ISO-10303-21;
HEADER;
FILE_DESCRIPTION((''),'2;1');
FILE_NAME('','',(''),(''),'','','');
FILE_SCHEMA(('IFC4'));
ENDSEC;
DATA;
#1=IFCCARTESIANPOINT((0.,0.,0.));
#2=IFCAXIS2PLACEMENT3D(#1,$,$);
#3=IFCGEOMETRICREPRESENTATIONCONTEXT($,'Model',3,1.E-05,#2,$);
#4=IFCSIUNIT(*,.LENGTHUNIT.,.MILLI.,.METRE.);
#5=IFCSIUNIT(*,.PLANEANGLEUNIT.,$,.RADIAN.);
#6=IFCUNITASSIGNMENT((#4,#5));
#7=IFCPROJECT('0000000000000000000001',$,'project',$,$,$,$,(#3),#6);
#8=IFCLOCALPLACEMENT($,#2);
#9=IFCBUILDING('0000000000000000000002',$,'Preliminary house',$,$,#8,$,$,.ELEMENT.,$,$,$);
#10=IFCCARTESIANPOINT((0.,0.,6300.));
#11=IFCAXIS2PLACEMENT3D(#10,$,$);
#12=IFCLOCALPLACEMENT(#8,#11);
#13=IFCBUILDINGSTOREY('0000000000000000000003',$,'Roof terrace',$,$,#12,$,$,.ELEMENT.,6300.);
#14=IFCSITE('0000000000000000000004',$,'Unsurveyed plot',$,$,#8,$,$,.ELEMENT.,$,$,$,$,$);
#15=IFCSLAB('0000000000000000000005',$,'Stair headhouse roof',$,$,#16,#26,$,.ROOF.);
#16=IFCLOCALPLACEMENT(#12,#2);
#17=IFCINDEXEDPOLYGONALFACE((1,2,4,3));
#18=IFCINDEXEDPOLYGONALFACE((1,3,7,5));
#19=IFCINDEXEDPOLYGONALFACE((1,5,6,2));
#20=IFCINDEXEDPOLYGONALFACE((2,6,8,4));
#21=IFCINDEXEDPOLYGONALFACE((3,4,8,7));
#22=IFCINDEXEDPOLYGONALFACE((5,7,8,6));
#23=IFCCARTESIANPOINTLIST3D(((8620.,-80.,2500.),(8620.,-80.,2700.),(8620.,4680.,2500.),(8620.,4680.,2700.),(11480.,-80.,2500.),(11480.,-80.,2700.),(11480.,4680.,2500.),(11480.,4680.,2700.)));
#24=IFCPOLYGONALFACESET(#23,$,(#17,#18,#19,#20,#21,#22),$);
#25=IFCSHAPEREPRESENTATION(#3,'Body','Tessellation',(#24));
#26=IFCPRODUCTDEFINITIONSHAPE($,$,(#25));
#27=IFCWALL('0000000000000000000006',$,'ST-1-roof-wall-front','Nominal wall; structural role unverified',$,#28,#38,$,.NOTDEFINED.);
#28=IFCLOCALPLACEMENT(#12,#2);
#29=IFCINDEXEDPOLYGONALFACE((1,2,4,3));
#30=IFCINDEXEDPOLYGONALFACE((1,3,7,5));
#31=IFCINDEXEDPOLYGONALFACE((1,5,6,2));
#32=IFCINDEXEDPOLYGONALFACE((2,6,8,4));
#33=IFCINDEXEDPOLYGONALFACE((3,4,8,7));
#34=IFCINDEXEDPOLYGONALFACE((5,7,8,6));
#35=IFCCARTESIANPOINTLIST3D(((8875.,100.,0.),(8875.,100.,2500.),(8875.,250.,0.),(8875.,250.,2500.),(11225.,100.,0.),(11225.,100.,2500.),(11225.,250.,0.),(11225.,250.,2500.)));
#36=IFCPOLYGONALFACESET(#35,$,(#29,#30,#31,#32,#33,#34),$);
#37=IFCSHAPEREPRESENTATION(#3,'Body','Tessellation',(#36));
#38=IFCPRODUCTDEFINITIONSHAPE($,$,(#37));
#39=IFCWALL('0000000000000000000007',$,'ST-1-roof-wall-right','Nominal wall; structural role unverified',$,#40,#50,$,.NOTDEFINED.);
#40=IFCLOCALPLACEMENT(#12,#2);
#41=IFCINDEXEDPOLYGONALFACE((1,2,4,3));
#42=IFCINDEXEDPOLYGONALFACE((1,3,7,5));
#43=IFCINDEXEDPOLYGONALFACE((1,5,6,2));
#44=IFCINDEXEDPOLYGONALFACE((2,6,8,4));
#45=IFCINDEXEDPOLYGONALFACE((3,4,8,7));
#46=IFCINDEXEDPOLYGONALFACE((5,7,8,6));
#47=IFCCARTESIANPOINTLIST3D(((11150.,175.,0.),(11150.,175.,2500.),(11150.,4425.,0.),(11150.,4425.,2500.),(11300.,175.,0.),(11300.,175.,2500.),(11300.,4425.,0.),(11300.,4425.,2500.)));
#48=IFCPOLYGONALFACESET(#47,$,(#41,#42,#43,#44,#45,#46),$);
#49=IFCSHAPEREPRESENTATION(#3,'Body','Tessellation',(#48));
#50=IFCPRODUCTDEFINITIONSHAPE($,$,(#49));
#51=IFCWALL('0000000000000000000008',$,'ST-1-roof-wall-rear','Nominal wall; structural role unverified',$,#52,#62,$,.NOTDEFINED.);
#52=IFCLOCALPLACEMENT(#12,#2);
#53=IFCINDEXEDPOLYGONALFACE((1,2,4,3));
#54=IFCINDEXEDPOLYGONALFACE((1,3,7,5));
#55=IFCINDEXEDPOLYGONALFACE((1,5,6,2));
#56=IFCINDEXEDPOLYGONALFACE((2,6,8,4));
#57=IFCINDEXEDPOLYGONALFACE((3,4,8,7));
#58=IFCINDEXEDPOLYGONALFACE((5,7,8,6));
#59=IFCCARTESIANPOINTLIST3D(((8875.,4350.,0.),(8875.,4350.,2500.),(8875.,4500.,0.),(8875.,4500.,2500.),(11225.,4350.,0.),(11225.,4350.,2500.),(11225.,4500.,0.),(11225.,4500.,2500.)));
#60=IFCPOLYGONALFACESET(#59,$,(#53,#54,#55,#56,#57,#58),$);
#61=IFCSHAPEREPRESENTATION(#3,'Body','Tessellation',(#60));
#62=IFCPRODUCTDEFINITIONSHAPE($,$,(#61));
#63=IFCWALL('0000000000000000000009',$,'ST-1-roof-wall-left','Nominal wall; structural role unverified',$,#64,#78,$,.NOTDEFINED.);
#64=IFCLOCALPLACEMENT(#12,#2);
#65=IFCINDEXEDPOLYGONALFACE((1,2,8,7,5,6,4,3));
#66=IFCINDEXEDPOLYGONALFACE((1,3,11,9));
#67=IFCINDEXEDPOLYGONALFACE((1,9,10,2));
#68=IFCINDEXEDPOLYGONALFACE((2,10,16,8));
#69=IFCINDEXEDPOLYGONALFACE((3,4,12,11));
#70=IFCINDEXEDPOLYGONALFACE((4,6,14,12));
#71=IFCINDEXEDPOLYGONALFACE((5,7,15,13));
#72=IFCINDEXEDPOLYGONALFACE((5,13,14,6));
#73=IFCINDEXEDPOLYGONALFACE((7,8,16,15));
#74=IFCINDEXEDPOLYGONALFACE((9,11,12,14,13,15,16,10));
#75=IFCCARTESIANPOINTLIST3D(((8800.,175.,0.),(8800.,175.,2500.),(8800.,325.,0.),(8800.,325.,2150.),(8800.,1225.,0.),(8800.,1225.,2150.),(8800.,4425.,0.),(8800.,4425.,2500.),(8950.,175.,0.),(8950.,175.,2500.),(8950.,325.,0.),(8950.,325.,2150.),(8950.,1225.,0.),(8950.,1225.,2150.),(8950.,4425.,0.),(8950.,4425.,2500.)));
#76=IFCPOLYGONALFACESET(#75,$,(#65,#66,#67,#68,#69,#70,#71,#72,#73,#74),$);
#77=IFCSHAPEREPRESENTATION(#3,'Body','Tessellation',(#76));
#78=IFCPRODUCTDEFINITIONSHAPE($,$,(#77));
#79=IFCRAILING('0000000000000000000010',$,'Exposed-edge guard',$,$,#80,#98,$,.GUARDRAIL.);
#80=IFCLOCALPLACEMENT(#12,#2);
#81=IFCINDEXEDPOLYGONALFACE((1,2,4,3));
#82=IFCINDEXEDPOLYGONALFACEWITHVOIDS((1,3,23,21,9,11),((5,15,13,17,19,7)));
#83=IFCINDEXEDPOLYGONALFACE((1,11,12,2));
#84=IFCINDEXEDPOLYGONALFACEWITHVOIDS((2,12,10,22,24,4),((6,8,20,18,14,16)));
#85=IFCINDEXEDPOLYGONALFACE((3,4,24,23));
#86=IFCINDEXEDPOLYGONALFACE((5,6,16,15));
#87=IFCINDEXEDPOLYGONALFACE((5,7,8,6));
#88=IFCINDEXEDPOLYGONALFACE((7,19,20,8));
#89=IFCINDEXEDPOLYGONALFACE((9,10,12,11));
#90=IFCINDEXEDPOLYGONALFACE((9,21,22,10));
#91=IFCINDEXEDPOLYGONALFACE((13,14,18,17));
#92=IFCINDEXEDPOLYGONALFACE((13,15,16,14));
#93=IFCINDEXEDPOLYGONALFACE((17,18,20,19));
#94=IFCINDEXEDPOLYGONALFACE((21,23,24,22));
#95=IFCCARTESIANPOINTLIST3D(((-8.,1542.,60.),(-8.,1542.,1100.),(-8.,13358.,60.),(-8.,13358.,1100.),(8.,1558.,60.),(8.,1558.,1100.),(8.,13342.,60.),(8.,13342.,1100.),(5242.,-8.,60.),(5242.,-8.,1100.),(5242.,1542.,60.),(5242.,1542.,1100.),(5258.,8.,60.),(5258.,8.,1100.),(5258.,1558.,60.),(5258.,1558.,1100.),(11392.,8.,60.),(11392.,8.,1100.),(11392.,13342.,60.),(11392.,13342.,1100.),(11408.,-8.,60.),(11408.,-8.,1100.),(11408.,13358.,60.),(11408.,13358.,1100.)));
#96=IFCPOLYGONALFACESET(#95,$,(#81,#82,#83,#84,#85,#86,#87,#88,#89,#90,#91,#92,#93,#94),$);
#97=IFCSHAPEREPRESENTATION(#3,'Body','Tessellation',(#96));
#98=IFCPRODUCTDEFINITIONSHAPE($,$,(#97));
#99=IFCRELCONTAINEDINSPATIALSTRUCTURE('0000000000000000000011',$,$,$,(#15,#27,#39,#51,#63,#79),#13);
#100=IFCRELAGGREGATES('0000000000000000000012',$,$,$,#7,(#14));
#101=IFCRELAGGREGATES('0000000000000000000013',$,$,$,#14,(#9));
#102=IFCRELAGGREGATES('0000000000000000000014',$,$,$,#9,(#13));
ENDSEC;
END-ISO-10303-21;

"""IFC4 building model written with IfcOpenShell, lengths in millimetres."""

from ifc_helpers import new_model, si_unit, frame, origin, place, context, project, spatial, polyline, outline, extrude, element, save


model = new_model("IFC4")

# Units and contexts
model_context = context("Model", 3, precision=1e-05, world=origin())
ifc_project = project(units=[si_unit("LENGTHUNIT", "METRE", prefix="MILLI"), si_unit("PLANEANGLEUNIT", "RADIAN")], contexts=[model_context])

# Site, building, storey
placement_1 = place(None, origin())
site = spatial("IfcSite", under=ifc_project, at=placement_1, Name="Unsurveyed plot", CompositionType="ELEMENT")
building = spatial("IfcBuilding", under=site, at=placement_1, Name="Preliminary house", CompositionType="ELEMENT")
placement_2 = place(placement_1, frame((0.0, 0.0, 6300.0)))
storey = spatial("IfcBuildingStorey", under=building, at=placement_2, Name="Roof terrace", CompositionType="ELEMENT", Elevation=6300.0)

# Slab
element("IfcSlab", 1, at=placement_2, inside=storey, Name="Stair headhouse roof", PredefinedType="ROOF", context=model_context, shape_type="SweptSolid", body=[
    extrude(outline(polyline([(11480.0, -80.0), (8620.0, -80.0), (8620.0, 4680.0), (11480.0, 4680.0), (11480.0, -80.0)])), frame((0.0, 0.0, 2500.0)), (0.0, 0.0, 1.0), 200.0),
])

# Walls
element("IfcWall", 2, at=placement_2, inside=storey, Name="ST-1-roof-wall-front", Description="Nominal wall; structural role unverified", PredefinedType="NOTDEFINED", context=model_context, shape_type="SweptSolid", body=[
    extrude(outline(polyline([(11225.0, 250.0), (11225.0, 100.0), (8875.0, 100.0), (8875.0, 250.0), (11225.0, 250.0)])), origin(), (0.0, 0.0, 1.0), 2500.0),
])
element("IfcWall", 3, at=placement_2, inside=storey, Name="ST-1-roof-wall-right", Description="Nominal wall; structural role unverified", PredefinedType="NOTDEFINED", context=model_context, shape_type="SweptSolid", body=[
    extrude(outline(polyline([(11150.0, 4425.0), (11300.0, 4425.0), (11300.0, 175.0), (11150.0, 175.0), (11150.0, 4425.0)])), origin(), (0.0, 0.0, 1.0), 2500.0),
])
element("IfcWall", 4, at=placement_2, inside=storey, Name="ST-1-roof-wall-rear", Description="Nominal wall; structural role unverified", PredefinedType="NOTDEFINED", context=model_context, shape_type="SweptSolid", body=[
    extrude(outline(polyline([(11225.0, 4500.0), (11225.0, 4350.0), (8875.0, 4350.0), (8875.0, 4500.0), (11225.0, 4500.0)])), origin(), (0.0, 0.0, 1.0), 2500.0),
])

# Wall, opening
wall_1 = element("IfcWall", 5, at=placement_2, inside=storey, Name="ST-1-roof-wall-left", Description="Nominal wall; structural role unverified", PredefinedType="NOTDEFINED", context=model_context, shape_type="SweptSolid", body=[
    extrude(outline(polyline([(8800.0, 4425.0), (8950.0, 4425.0), (8950.0, 175.0), (8800.0, 175.0), (8800.0, 4425.0)])), origin(), (0.0, 0.0, 1.0), 2500.0),
])
element("IfcOpeningElement", 6, at=placement_2, cuts=wall_1, PredefinedType="OPENING", context=model_context, shape_type="SweptSolid", body=[
    extrude(outline(polyline([(9325.0, 325.0), (9325.0, 1225.0), (8425.0, 1225.0), (8425.0, 325.0), (9325.0, 325.0)])), origin(), (0.0, 0.0, 1.0), 2150.0),
])

# Railing
element("IfcRailing", 7, at=placement_2, inside=storey, Name="Exposed-edge guard", PredefinedType="GUARDRAIL", context=model_context, shape_type="SweptSolid", body=[
    extrude(outline(polyline([(-8.0, 13358.0), (11408.0, 13358.0), (11408.0, -8.0), (5242.0, -8.0), (5242.0, 1542.0), (-8.0, 1542.0), (-8.0, 13358.0)]), holes=[polyline([(8.0, 13342.0), (8.0, 1558.0), (5258.0, 1558.0), (5258.0, 8.0), (11392.0, 8.0), (11392.0, 13342.0), (8.0, 13342.0)])]), frame((0.0, 0.0, 60.0)), (0.0, 0.0, 1.0), 1040.0),
])

save(model, "model.ifc")
